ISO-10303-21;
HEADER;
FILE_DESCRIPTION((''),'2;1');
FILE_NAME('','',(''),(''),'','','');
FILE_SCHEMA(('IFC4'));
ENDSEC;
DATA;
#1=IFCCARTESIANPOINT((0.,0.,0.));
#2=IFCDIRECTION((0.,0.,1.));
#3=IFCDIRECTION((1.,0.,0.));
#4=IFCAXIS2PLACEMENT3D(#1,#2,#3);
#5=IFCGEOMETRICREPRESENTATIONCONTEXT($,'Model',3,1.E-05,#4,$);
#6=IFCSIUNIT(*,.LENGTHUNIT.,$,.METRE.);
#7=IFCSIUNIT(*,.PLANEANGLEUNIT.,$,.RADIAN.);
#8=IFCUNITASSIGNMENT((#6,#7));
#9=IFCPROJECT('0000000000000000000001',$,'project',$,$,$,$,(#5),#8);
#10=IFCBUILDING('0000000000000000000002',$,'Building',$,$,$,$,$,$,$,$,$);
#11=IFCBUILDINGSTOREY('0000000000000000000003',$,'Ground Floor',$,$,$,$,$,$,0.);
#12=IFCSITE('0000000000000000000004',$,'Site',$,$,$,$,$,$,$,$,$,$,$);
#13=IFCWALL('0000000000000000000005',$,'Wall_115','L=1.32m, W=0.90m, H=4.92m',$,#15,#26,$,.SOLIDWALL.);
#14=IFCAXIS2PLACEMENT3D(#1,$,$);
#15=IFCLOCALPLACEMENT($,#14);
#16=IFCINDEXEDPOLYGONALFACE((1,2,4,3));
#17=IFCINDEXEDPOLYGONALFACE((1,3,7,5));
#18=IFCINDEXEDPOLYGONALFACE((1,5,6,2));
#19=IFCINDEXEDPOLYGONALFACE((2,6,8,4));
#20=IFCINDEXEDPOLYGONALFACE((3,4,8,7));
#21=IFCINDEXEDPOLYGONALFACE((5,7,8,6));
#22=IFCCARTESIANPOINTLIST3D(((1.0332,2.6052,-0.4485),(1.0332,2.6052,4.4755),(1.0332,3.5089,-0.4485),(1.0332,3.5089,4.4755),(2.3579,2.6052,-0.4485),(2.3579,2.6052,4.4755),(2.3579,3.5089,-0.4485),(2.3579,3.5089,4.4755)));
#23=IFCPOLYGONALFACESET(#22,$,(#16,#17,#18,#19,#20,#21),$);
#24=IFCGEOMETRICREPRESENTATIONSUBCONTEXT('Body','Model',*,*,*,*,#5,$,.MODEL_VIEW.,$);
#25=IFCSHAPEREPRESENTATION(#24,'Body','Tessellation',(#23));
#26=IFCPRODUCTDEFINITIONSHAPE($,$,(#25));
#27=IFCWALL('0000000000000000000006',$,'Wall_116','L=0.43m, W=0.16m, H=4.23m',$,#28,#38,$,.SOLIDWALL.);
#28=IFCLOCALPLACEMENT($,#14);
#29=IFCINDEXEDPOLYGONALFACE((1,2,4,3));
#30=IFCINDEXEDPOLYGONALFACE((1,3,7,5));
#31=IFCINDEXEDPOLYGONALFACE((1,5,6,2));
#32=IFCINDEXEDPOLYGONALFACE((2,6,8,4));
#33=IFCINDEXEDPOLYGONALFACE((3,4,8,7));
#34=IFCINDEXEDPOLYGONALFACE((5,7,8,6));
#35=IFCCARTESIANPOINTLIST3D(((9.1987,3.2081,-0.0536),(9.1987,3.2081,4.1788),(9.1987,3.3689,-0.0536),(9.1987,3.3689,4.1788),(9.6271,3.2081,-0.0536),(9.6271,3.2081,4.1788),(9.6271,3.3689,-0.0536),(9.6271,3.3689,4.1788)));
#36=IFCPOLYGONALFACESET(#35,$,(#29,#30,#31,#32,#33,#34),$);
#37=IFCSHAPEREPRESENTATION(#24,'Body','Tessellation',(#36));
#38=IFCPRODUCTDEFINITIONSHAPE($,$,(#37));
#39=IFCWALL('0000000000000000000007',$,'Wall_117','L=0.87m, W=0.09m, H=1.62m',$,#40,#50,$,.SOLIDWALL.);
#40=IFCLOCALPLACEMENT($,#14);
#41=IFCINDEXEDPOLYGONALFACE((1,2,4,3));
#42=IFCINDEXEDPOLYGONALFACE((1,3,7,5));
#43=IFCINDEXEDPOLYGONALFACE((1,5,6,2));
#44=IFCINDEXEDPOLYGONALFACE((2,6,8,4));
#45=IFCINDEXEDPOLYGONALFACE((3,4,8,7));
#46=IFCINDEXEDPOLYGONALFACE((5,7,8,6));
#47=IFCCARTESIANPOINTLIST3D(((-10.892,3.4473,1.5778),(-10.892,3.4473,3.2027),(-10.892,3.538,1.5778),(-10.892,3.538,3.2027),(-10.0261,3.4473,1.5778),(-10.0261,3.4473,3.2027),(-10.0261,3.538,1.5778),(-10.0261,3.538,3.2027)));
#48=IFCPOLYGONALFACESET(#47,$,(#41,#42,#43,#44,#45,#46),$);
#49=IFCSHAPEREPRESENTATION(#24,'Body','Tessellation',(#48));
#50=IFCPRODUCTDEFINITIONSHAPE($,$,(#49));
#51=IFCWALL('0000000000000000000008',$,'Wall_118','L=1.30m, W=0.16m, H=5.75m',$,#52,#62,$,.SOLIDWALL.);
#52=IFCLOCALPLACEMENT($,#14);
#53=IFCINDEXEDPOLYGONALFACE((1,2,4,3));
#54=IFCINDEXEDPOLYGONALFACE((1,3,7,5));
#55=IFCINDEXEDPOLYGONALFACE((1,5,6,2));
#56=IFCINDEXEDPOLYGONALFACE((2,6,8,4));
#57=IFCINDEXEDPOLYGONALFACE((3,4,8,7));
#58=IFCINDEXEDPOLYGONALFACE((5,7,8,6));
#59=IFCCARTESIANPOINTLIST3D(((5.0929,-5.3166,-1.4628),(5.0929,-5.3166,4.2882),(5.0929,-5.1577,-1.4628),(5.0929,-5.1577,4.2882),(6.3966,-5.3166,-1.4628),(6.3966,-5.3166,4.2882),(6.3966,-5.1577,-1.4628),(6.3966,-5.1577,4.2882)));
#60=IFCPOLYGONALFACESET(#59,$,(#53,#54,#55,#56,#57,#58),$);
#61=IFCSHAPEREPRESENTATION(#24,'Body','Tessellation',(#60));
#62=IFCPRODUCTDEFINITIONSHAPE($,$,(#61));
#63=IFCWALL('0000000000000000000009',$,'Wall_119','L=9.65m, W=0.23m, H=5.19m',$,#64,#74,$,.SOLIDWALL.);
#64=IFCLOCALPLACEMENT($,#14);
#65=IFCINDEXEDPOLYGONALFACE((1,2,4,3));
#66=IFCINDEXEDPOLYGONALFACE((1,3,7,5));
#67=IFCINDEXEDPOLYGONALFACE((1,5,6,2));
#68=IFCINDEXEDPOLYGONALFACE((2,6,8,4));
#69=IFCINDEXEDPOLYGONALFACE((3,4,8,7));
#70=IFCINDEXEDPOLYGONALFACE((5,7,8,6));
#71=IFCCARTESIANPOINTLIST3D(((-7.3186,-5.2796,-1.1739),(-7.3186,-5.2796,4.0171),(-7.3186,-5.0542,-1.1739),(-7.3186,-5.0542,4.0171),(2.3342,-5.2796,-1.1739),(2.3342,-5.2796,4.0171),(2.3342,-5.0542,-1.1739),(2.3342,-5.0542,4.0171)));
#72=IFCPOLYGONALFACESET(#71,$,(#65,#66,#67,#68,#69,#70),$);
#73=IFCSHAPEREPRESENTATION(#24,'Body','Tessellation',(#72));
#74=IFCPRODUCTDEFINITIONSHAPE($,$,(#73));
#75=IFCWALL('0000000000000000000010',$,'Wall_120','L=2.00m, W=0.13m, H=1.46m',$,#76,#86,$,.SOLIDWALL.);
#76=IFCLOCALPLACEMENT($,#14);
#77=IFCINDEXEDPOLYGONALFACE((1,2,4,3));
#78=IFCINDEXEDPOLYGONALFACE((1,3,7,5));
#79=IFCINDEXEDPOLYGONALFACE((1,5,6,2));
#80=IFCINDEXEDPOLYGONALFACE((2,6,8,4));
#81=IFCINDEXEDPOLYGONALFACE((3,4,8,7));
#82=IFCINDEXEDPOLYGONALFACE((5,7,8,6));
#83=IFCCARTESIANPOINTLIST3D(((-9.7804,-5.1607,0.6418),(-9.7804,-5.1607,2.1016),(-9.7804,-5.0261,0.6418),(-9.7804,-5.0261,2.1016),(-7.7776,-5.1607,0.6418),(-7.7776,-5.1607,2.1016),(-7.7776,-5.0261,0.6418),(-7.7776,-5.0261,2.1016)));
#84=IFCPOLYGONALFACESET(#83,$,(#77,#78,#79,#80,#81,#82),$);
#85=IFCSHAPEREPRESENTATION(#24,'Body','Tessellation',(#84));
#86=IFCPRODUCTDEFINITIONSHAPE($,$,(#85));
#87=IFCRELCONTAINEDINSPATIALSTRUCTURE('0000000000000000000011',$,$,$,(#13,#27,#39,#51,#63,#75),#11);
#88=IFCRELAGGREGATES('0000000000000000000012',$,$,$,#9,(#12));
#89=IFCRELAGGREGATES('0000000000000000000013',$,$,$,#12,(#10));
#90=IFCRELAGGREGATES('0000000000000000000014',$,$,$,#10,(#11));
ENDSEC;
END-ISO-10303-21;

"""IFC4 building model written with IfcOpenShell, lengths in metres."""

from ifc_helpers import new_model, si_unit, frame, origin_with_axes, origin_2d, context, subcontext, project, spatial, rectangle, extrude, element, save


model = new_model("IFC4")

# Units and contexts
model_context = context("Model", 3, precision=1e-05, world=origin_with_axes())
body_context = subcontext(model_context, "Body", "Model", "MODEL_VIEW")
ifc_project = project(units=[si_unit("LENGTHUNIT", "METRE"), si_unit("PLANEANGLEUNIT", "RADIAN")], contexts=[model_context])

# Site, building, storey
site = spatial("IfcSite", under=ifc_project, Name="Site")
building = spatial("IfcBuilding", under=site, Name="Building")
storey = spatial("IfcBuildingStorey", under=building, Name="Ground Floor", Elevation=0.0)

# Walls
element("IfcWall", 1, inside=storey, Name="Wall_115", Description="L=1.32m, W=0.90m, H=4.92m", PredefinedType="SOLIDWALL", context=body_context, shape_type="SweptSolid", body=[
    extrude(rectangle(XDim=1.3247, YDim=0.9036, at=origin_2d()), frame((1.6956, 3.057, -0.4485), z_axis=(0.0, 0.0, 1.0), x_axis=(1.0, 0.0, 0.0)), (0.0, 0.0, 1.0), 4.924),
])
element("IfcWall", 2, inside=storey, Name="Wall_116", Description="L=0.43m, W=0.16m, H=4.23m", PredefinedType="SOLIDWALL", context=body_context, shape_type="SweptSolid", body=[
    extrude(rectangle(XDim=0.4285, YDim=0.1607, at=origin_2d()), frame((9.4129, 3.2885, -0.0536), z_axis=(0.0, 0.0, 1.0), x_axis=(1.0, 0.0, 0.0)), (0.0, 0.0, 1.0), 4.2324),
])
element("IfcWall", 3, inside=storey, Name="Wall_117", Description="L=0.87m, W=0.09m, H=1.62m", PredefinedType="SOLIDWALL", context=body_context, shape_type="SweptSolid", body=[
    extrude(rectangle(XDim=0.8659, YDim=0.0907, at=origin_2d()), frame((-10.4591, 3.4926, 1.5778), z_axis=(0.0, 0.0, 1.0), x_axis=(1.0, 0.0, 0.0)), (0.0, 0.0, 1.0), 1.6249),
])
element("IfcWall", 4, inside=storey, Name="Wall_118", Description="L=1.30m, W=0.16m, H=5.75m", PredefinedType="SOLIDWALL", context=body_context, shape_type="SweptSolid", body=[
    extrude(rectangle(XDim=1.3037, YDim=0.1589, at=origin_2d()), frame((5.7448, -5.2371, -1.4628), z_axis=(0.0, 0.0, 1.0), x_axis=(1.0, 0.0, 0.0)), (0.0, 0.0, 1.0), 5.751),
])
element("IfcWall", 5, inside=storey, Name="Wall_119", Description="L=9.65m, W=0.23m, H=5.19m", PredefinedType="SOLIDWALL", context=body_context, shape_type="SweptSolid", body=[
    extrude(rectangle(XDim=9.6528, YDim=0.2254, at=origin_2d()), frame((-2.4922, -5.1669, -1.1739), z_axis=(0.0, 0.0, 1.0), x_axis=(1.0, 0.0, 0.0)), (0.0, 0.0, 1.0), 5.191),
])
element("IfcWall", 6, inside=storey, Name="Wall_120", Description="L=2.00m, W=0.13m, H=1.46m", PredefinedType="SOLIDWALL", context=body_context, shape_type="SweptSolid", body=[
    extrude(rectangle(XDim=2.0028, YDim=0.1346, at=origin_2d()), frame((-8.779, -5.0934, 0.6418), z_axis=(0.0, 0.0, 1.0), x_axis=(1.0, 0.0, 0.0)), (0.0, 0.0, 1.0), 1.4598),
])

save(model, "model.ifc")
